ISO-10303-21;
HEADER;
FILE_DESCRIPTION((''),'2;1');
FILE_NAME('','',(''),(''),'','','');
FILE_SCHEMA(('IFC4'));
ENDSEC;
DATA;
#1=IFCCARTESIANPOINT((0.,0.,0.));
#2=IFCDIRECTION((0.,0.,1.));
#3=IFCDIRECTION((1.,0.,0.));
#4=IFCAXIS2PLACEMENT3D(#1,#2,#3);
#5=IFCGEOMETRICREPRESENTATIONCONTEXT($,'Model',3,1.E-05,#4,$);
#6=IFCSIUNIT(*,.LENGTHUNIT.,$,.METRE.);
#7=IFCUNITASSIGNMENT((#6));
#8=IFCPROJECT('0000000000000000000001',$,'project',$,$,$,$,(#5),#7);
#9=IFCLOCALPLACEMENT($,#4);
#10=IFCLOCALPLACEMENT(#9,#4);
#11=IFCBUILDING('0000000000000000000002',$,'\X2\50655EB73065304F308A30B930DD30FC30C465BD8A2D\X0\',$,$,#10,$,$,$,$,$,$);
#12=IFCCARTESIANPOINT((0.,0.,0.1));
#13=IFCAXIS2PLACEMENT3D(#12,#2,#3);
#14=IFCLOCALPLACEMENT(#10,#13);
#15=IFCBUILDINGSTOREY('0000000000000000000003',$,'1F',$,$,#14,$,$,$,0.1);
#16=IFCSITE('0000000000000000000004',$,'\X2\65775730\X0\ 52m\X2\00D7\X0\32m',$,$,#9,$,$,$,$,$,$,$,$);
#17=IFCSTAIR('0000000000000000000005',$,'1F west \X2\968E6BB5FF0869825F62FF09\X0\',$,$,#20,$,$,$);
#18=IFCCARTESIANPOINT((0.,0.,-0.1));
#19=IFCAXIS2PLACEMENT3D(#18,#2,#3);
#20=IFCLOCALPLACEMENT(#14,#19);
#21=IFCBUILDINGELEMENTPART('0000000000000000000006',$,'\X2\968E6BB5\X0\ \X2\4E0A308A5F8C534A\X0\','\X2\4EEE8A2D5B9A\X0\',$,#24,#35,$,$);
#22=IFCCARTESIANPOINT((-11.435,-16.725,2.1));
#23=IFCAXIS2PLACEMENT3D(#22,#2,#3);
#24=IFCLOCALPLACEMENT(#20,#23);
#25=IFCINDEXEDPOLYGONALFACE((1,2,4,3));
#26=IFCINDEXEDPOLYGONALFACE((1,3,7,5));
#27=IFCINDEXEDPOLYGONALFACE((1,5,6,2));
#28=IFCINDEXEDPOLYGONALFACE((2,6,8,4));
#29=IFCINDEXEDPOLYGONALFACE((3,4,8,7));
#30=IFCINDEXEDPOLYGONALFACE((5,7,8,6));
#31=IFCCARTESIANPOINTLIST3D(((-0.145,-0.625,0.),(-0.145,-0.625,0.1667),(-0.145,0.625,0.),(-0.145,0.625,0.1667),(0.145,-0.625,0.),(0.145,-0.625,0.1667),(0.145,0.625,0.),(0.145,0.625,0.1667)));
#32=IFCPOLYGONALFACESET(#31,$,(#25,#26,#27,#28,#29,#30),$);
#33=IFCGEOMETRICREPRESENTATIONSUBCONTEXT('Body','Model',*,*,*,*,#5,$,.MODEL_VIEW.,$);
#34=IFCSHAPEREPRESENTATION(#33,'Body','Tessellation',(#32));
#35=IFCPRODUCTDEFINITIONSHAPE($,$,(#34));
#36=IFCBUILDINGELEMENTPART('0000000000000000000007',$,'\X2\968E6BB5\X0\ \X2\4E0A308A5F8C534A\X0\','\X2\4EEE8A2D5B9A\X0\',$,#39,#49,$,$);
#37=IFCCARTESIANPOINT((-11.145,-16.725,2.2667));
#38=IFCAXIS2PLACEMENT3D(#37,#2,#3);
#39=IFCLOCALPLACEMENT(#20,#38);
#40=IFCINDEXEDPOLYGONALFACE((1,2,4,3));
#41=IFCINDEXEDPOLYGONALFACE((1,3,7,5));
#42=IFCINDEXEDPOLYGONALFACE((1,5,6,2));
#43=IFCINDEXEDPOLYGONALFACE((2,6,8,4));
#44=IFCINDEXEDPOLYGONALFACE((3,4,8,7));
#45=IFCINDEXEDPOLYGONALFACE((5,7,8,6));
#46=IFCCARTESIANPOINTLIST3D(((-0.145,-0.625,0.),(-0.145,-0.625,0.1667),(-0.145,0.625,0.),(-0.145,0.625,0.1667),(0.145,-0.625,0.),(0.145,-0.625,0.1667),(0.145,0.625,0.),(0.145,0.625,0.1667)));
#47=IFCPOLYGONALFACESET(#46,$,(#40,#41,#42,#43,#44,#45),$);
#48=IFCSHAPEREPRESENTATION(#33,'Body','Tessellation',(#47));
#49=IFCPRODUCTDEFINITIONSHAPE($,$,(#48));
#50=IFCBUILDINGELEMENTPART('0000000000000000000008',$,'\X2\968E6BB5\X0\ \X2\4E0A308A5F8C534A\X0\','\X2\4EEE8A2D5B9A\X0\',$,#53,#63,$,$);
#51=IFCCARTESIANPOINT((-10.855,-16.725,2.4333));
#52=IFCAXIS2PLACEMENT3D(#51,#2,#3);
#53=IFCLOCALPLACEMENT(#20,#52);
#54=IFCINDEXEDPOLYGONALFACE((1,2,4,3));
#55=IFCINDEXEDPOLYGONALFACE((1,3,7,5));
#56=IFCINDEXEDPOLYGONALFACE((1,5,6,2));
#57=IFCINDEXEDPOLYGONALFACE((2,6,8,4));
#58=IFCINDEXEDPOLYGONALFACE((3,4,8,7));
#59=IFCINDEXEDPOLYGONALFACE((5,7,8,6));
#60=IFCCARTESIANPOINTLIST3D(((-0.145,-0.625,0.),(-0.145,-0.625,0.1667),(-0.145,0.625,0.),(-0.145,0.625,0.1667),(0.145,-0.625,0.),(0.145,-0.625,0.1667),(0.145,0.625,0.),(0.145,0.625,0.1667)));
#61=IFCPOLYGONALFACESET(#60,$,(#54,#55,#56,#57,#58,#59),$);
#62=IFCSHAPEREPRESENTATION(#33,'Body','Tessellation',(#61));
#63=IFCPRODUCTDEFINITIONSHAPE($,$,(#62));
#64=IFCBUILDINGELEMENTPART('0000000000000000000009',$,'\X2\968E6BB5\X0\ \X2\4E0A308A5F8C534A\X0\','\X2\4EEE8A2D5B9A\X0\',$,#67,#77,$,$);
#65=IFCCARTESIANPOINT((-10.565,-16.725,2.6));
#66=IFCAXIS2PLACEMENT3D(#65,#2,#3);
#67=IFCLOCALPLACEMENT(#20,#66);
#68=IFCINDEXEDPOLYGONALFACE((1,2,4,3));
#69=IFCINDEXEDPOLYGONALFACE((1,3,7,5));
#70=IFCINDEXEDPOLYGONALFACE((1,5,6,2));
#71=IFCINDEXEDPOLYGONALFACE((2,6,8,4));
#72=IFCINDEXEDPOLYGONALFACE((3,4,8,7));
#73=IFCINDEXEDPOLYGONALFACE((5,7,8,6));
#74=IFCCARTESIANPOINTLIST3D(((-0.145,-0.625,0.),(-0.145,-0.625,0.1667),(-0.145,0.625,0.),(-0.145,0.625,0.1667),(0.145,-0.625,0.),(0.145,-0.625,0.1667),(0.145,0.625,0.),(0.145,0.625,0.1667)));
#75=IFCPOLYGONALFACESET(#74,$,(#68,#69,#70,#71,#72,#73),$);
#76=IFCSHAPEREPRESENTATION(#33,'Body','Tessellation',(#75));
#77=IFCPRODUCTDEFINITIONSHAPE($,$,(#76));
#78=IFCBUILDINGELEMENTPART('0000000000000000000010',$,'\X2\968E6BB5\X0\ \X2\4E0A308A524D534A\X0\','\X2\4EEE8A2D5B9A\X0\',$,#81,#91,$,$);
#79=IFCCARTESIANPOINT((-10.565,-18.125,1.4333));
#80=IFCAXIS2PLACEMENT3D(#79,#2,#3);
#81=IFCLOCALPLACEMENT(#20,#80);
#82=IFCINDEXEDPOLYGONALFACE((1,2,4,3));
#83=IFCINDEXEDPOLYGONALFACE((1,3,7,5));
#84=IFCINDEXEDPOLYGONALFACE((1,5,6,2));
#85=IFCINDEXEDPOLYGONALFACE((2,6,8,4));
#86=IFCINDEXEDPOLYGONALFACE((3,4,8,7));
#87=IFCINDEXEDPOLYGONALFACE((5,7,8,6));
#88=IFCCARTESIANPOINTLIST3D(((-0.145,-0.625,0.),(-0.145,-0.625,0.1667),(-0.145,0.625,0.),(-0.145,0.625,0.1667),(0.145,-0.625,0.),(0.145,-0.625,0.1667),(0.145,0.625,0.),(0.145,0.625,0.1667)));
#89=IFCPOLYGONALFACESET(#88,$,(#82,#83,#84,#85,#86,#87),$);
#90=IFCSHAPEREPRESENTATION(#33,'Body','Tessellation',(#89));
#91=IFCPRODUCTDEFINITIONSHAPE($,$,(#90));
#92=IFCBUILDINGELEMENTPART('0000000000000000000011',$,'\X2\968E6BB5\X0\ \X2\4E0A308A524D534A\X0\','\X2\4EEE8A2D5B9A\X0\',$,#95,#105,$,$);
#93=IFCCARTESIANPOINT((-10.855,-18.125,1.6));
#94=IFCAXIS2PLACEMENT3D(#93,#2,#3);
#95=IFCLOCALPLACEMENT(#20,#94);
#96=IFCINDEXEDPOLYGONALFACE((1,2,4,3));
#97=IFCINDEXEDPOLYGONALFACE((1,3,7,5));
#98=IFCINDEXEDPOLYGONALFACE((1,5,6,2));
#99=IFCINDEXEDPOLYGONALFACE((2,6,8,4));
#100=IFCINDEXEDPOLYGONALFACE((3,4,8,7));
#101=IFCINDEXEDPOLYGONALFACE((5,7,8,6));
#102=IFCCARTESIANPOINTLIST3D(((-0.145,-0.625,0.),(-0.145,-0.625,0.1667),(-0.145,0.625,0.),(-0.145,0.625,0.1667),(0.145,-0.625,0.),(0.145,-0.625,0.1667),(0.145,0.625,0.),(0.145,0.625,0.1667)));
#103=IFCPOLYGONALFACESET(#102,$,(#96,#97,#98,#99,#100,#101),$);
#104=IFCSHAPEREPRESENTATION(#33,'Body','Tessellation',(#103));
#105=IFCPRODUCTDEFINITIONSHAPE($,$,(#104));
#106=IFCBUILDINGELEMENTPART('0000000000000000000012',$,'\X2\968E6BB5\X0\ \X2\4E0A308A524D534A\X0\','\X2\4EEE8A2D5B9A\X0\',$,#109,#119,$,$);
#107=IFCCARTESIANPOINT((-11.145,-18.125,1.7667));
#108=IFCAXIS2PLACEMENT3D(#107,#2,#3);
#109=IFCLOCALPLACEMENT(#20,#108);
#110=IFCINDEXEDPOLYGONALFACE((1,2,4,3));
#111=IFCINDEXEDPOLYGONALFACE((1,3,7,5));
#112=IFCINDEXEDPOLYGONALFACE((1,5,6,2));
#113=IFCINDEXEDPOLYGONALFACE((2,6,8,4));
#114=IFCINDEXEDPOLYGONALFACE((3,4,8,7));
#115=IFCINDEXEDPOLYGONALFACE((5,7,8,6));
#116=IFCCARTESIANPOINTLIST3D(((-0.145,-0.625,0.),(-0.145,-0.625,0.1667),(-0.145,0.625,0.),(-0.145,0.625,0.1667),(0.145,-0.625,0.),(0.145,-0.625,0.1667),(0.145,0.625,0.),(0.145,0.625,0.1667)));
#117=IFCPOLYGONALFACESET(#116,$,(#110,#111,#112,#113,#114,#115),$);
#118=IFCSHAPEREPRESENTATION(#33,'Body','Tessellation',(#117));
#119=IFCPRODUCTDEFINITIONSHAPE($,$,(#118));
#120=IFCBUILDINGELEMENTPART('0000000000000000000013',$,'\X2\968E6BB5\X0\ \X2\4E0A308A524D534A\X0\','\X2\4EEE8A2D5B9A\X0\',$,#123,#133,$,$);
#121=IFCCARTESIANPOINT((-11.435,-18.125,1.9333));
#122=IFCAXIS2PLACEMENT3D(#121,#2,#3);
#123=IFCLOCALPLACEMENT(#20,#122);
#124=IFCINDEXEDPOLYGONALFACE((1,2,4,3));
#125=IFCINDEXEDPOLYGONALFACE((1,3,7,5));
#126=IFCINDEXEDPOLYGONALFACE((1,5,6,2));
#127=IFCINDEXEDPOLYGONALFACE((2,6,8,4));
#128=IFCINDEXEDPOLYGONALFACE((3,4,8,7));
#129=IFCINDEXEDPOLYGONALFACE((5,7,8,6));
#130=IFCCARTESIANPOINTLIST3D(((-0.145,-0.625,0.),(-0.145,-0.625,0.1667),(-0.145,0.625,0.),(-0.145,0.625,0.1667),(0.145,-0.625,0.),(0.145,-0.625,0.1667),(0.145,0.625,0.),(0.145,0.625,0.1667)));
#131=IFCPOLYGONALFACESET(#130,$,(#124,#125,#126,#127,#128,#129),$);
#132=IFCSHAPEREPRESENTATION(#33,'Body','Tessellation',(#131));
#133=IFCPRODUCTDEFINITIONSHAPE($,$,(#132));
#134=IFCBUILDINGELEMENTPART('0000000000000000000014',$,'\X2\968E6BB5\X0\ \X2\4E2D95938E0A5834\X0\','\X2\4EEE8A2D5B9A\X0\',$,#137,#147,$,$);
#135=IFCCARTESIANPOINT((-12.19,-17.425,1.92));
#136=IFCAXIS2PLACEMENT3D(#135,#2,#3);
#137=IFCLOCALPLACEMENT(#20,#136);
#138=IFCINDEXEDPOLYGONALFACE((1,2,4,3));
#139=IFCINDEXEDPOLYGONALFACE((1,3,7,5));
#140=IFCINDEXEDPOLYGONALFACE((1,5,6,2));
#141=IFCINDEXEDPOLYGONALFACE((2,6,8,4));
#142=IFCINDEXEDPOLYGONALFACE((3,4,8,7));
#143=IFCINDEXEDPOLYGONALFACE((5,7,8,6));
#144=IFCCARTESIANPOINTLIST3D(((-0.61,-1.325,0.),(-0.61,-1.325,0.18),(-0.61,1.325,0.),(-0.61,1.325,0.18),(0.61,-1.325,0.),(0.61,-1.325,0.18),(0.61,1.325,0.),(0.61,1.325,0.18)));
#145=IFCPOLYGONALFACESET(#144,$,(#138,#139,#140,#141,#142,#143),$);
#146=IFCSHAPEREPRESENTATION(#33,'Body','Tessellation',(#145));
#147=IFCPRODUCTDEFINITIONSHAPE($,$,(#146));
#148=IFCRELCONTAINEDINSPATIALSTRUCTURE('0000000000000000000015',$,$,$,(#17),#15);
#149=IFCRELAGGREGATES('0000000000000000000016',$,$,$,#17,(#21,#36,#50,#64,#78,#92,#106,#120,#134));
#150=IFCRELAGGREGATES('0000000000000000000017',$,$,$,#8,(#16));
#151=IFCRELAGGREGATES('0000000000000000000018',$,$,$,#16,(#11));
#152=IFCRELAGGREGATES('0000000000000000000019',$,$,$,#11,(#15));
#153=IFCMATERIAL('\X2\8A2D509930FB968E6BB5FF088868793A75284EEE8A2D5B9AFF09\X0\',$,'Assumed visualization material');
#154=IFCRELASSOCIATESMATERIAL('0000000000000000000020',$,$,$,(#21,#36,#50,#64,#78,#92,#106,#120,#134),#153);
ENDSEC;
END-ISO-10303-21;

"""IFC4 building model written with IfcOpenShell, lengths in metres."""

from ifc_helpers import new_model, si_unit, frame, origin_with_axes, place, context, subcontext, project, spatial, rectangle, extrude, material, element, aggregate, save


model = new_model("IFC4")

# Units and contexts
model_context = context("Model", 3, precision=1e-05, world=origin_with_axes())
body_context = subcontext(model_context, "Body", "Model", "MODEL_VIEW")
ifc_project = project(units=[si_unit("LENGTHUNIT", "METRE")], contexts=[model_context])

# Site, building, storey
site_placement = place(None, origin_with_axes())
site = spatial("IfcSite", under=ifc_project, at=site_placement, Name="敷地 52m×32m")
building_placement = place(site_placement, origin_with_axes())
building = spatial("IfcBuilding", under=site, at=building_placement, Name="健康づくりスポーツ施設")
storey_placement = place(building_placement, frame((0.0, 0.0, 0.1), z_axis=(0.0, 0.0, 1.0), x_axis=(1.0, 0.0, 0.0)))
storey = spatial("IfcBuildingStorey", under=building, at=storey_placement, Name="1F", Elevation=0.1)

# Stair, building element parts
stair_placement = place(storey_placement, frame((0.0, 0.0, -0.1), z_axis=(0.0, 0.0, 1.0), x_axis=(1.0, 0.0, 0.0)))
stair = element("IfcStair", 1, at=stair_placement, inside=storey, Name="1F west 階段（概形）")
ifc_material_1 = material(Name="設備・階段（表示用仮設定）", Category="Assumed visualization material")
building_element_part_1_placement = place(stair_placement, frame((-11.435, -16.725, 2.1), z_axis=(0.0, 0.0, 1.0), x_axis=(1.0, 0.0, 0.0)))
building_element_part_1 = element("IfcBuildingElementPart", 2, at=building_element_part_1_placement, material=ifc_material_1, Name="階段 上り後半", Description="仮設定", context=body_context, shape_type="SweptSolid", body=[
    extrude(rectangle(XDim=0.29, YDim=1.25), origin_with_axes(), (0.0, 0.0, 1.0), 0.1667),
])
building_element_part_2_placement = place(stair_placement, frame((-11.145, -16.725, 2.2667), z_axis=(0.0, 0.0, 1.0), x_axis=(1.0, 0.0, 0.0)))
building_element_part_2 = element("IfcBuildingElementPart", 3, at=building_element_part_2_placement, material=ifc_material_1, Name="階段 上り後半", Description="仮設定", context=body_context, shape_type="SweptSolid", body=[
    extrude(rectangle(XDim=0.29, YDim=1.25), origin_with_axes(), (0.0, 0.0, 1.0), 0.1667),
])
building_element_part_3_placement = place(stair_placement, frame((-10.855, -16.725, 2.4333), z_axis=(0.0, 0.0, 1.0), x_axis=(1.0, 0.0, 0.0)))
building_element_part_3 = element("IfcBuildingElementPart", 4, at=building_element_part_3_placement, material=ifc_material_1, Name="階段 上り後半", Description="仮設定", context=body_context, shape_type="SweptSolid", body=[
    extrude(rectangle(XDim=0.29, YDim=1.25), origin_with_axes(), (0.0, 0.0, 1.0), 0.1667),
])
building_element_part_4_placement = place(stair_placement, frame((-10.565, -16.725, 2.6), z_axis=(0.0, 0.0, 1.0), x_axis=(1.0, 0.0, 0.0)))
building_element_part_4 = element("IfcBuildingElementPart", 5, at=building_element_part_4_placement, material=ifc_material_1, Name="階段 上り後半", Description="仮設定", context=body_context, shape_type="SweptSolid", body=[
    extrude(rectangle(XDim=0.29, YDim=1.25), origin_with_axes(), (0.0, 0.0, 1.0), 0.1667),
])
building_element_part_5_placement = place(stair_placement, frame((-10.565, -18.125, 1.4333), z_axis=(0.0, 0.0, 1.0), x_axis=(1.0, 0.0, 0.0)))
building_element_part_5 = element("IfcBuildingElementPart", 6, at=building_element_part_5_placement, material=ifc_material_1, Name="階段 上り前半", Description="仮設定", context=body_context, shape_type="SweptSolid", body=[
    extrude(rectangle(XDim=0.29, YDim=1.25), origin_with_axes(), (0.0, 0.0, 1.0), 0.1667),
])
building_element_part_6_placement = place(stair_placement, frame((-10.855, -18.125, 1.6), z_axis=(0.0, 0.0, 1.0), x_axis=(1.0, 0.0, 0.0)))
building_element_part_6 = element("IfcBuildingElementPart", 7, at=building_element_part_6_placement, material=ifc_material_1, Name="階段 上り前半", Description="仮設定", context=body_context, shape_type="SweptSolid", body=[
    extrude(rectangle(XDim=0.29, YDim=1.25), origin_with_axes(), (0.0, 0.0, 1.0), 0.1667),
])
building_element_part_7_placement = place(stair_placement, frame((-11.145, -18.125, 1.7667), z_axis=(0.0, 0.0, 1.0), x_axis=(1.0, 0.0, 0.0)))
building_element_part_7 = element("IfcBuildingElementPart", 8, at=building_element_part_7_placement, material=ifc_material_1, Name="階段 上り前半", Description="仮設定", context=body_context, shape_type="SweptSolid", body=[
    extrude(rectangle(XDim=0.29, YDim=1.25), origin_with_axes(), (0.0, 0.0, 1.0), 0.1667),
])
building_element_part_8_placement = place(stair_placement, frame((-11.435, -18.125, 1.9333), z_axis=(0.0, 0.0, 1.0), x_axis=(1.0, 0.0, 0.0)))
building_element_part_8 = element("IfcBuildingElementPart", 9, at=building_element_part_8_placement, material=ifc_material_1, Name="階段 上り前半", Description="仮設定", context=body_context, shape_type="SweptSolid", body=[
    extrude(rectangle(XDim=0.29, YDim=1.25), origin_with_axes(), (0.0, 0.0, 1.0), 0.1667),
])
building_element_part_9_placement = place(stair_placement, frame((-12.19, -17.425, 1.92), z_axis=(0.0, 0.0, 1.0), x_axis=(1.0, 0.0, 0.0)))
building_element_part_9 = element("IfcBuildingElementPart", 10, at=building_element_part_9_placement, material=ifc_material_1, Name="階段 中間踊場", Description="仮設定", context=body_context, shape_type="SweptSolid", body=[
    extrude(rectangle(XDim=1.22, YDim=2.65), origin_with_axes(), (0.0, 0.0, 1.0), 0.18),
])
aggregate(stair, [building_element_part_1, building_element_part_2, building_element_part_3, building_element_part_4, building_element_part_5, building_element_part_6, building_element_part_7, building_element_part_8, building_element_part_9])

save(model, "model.ifc")
